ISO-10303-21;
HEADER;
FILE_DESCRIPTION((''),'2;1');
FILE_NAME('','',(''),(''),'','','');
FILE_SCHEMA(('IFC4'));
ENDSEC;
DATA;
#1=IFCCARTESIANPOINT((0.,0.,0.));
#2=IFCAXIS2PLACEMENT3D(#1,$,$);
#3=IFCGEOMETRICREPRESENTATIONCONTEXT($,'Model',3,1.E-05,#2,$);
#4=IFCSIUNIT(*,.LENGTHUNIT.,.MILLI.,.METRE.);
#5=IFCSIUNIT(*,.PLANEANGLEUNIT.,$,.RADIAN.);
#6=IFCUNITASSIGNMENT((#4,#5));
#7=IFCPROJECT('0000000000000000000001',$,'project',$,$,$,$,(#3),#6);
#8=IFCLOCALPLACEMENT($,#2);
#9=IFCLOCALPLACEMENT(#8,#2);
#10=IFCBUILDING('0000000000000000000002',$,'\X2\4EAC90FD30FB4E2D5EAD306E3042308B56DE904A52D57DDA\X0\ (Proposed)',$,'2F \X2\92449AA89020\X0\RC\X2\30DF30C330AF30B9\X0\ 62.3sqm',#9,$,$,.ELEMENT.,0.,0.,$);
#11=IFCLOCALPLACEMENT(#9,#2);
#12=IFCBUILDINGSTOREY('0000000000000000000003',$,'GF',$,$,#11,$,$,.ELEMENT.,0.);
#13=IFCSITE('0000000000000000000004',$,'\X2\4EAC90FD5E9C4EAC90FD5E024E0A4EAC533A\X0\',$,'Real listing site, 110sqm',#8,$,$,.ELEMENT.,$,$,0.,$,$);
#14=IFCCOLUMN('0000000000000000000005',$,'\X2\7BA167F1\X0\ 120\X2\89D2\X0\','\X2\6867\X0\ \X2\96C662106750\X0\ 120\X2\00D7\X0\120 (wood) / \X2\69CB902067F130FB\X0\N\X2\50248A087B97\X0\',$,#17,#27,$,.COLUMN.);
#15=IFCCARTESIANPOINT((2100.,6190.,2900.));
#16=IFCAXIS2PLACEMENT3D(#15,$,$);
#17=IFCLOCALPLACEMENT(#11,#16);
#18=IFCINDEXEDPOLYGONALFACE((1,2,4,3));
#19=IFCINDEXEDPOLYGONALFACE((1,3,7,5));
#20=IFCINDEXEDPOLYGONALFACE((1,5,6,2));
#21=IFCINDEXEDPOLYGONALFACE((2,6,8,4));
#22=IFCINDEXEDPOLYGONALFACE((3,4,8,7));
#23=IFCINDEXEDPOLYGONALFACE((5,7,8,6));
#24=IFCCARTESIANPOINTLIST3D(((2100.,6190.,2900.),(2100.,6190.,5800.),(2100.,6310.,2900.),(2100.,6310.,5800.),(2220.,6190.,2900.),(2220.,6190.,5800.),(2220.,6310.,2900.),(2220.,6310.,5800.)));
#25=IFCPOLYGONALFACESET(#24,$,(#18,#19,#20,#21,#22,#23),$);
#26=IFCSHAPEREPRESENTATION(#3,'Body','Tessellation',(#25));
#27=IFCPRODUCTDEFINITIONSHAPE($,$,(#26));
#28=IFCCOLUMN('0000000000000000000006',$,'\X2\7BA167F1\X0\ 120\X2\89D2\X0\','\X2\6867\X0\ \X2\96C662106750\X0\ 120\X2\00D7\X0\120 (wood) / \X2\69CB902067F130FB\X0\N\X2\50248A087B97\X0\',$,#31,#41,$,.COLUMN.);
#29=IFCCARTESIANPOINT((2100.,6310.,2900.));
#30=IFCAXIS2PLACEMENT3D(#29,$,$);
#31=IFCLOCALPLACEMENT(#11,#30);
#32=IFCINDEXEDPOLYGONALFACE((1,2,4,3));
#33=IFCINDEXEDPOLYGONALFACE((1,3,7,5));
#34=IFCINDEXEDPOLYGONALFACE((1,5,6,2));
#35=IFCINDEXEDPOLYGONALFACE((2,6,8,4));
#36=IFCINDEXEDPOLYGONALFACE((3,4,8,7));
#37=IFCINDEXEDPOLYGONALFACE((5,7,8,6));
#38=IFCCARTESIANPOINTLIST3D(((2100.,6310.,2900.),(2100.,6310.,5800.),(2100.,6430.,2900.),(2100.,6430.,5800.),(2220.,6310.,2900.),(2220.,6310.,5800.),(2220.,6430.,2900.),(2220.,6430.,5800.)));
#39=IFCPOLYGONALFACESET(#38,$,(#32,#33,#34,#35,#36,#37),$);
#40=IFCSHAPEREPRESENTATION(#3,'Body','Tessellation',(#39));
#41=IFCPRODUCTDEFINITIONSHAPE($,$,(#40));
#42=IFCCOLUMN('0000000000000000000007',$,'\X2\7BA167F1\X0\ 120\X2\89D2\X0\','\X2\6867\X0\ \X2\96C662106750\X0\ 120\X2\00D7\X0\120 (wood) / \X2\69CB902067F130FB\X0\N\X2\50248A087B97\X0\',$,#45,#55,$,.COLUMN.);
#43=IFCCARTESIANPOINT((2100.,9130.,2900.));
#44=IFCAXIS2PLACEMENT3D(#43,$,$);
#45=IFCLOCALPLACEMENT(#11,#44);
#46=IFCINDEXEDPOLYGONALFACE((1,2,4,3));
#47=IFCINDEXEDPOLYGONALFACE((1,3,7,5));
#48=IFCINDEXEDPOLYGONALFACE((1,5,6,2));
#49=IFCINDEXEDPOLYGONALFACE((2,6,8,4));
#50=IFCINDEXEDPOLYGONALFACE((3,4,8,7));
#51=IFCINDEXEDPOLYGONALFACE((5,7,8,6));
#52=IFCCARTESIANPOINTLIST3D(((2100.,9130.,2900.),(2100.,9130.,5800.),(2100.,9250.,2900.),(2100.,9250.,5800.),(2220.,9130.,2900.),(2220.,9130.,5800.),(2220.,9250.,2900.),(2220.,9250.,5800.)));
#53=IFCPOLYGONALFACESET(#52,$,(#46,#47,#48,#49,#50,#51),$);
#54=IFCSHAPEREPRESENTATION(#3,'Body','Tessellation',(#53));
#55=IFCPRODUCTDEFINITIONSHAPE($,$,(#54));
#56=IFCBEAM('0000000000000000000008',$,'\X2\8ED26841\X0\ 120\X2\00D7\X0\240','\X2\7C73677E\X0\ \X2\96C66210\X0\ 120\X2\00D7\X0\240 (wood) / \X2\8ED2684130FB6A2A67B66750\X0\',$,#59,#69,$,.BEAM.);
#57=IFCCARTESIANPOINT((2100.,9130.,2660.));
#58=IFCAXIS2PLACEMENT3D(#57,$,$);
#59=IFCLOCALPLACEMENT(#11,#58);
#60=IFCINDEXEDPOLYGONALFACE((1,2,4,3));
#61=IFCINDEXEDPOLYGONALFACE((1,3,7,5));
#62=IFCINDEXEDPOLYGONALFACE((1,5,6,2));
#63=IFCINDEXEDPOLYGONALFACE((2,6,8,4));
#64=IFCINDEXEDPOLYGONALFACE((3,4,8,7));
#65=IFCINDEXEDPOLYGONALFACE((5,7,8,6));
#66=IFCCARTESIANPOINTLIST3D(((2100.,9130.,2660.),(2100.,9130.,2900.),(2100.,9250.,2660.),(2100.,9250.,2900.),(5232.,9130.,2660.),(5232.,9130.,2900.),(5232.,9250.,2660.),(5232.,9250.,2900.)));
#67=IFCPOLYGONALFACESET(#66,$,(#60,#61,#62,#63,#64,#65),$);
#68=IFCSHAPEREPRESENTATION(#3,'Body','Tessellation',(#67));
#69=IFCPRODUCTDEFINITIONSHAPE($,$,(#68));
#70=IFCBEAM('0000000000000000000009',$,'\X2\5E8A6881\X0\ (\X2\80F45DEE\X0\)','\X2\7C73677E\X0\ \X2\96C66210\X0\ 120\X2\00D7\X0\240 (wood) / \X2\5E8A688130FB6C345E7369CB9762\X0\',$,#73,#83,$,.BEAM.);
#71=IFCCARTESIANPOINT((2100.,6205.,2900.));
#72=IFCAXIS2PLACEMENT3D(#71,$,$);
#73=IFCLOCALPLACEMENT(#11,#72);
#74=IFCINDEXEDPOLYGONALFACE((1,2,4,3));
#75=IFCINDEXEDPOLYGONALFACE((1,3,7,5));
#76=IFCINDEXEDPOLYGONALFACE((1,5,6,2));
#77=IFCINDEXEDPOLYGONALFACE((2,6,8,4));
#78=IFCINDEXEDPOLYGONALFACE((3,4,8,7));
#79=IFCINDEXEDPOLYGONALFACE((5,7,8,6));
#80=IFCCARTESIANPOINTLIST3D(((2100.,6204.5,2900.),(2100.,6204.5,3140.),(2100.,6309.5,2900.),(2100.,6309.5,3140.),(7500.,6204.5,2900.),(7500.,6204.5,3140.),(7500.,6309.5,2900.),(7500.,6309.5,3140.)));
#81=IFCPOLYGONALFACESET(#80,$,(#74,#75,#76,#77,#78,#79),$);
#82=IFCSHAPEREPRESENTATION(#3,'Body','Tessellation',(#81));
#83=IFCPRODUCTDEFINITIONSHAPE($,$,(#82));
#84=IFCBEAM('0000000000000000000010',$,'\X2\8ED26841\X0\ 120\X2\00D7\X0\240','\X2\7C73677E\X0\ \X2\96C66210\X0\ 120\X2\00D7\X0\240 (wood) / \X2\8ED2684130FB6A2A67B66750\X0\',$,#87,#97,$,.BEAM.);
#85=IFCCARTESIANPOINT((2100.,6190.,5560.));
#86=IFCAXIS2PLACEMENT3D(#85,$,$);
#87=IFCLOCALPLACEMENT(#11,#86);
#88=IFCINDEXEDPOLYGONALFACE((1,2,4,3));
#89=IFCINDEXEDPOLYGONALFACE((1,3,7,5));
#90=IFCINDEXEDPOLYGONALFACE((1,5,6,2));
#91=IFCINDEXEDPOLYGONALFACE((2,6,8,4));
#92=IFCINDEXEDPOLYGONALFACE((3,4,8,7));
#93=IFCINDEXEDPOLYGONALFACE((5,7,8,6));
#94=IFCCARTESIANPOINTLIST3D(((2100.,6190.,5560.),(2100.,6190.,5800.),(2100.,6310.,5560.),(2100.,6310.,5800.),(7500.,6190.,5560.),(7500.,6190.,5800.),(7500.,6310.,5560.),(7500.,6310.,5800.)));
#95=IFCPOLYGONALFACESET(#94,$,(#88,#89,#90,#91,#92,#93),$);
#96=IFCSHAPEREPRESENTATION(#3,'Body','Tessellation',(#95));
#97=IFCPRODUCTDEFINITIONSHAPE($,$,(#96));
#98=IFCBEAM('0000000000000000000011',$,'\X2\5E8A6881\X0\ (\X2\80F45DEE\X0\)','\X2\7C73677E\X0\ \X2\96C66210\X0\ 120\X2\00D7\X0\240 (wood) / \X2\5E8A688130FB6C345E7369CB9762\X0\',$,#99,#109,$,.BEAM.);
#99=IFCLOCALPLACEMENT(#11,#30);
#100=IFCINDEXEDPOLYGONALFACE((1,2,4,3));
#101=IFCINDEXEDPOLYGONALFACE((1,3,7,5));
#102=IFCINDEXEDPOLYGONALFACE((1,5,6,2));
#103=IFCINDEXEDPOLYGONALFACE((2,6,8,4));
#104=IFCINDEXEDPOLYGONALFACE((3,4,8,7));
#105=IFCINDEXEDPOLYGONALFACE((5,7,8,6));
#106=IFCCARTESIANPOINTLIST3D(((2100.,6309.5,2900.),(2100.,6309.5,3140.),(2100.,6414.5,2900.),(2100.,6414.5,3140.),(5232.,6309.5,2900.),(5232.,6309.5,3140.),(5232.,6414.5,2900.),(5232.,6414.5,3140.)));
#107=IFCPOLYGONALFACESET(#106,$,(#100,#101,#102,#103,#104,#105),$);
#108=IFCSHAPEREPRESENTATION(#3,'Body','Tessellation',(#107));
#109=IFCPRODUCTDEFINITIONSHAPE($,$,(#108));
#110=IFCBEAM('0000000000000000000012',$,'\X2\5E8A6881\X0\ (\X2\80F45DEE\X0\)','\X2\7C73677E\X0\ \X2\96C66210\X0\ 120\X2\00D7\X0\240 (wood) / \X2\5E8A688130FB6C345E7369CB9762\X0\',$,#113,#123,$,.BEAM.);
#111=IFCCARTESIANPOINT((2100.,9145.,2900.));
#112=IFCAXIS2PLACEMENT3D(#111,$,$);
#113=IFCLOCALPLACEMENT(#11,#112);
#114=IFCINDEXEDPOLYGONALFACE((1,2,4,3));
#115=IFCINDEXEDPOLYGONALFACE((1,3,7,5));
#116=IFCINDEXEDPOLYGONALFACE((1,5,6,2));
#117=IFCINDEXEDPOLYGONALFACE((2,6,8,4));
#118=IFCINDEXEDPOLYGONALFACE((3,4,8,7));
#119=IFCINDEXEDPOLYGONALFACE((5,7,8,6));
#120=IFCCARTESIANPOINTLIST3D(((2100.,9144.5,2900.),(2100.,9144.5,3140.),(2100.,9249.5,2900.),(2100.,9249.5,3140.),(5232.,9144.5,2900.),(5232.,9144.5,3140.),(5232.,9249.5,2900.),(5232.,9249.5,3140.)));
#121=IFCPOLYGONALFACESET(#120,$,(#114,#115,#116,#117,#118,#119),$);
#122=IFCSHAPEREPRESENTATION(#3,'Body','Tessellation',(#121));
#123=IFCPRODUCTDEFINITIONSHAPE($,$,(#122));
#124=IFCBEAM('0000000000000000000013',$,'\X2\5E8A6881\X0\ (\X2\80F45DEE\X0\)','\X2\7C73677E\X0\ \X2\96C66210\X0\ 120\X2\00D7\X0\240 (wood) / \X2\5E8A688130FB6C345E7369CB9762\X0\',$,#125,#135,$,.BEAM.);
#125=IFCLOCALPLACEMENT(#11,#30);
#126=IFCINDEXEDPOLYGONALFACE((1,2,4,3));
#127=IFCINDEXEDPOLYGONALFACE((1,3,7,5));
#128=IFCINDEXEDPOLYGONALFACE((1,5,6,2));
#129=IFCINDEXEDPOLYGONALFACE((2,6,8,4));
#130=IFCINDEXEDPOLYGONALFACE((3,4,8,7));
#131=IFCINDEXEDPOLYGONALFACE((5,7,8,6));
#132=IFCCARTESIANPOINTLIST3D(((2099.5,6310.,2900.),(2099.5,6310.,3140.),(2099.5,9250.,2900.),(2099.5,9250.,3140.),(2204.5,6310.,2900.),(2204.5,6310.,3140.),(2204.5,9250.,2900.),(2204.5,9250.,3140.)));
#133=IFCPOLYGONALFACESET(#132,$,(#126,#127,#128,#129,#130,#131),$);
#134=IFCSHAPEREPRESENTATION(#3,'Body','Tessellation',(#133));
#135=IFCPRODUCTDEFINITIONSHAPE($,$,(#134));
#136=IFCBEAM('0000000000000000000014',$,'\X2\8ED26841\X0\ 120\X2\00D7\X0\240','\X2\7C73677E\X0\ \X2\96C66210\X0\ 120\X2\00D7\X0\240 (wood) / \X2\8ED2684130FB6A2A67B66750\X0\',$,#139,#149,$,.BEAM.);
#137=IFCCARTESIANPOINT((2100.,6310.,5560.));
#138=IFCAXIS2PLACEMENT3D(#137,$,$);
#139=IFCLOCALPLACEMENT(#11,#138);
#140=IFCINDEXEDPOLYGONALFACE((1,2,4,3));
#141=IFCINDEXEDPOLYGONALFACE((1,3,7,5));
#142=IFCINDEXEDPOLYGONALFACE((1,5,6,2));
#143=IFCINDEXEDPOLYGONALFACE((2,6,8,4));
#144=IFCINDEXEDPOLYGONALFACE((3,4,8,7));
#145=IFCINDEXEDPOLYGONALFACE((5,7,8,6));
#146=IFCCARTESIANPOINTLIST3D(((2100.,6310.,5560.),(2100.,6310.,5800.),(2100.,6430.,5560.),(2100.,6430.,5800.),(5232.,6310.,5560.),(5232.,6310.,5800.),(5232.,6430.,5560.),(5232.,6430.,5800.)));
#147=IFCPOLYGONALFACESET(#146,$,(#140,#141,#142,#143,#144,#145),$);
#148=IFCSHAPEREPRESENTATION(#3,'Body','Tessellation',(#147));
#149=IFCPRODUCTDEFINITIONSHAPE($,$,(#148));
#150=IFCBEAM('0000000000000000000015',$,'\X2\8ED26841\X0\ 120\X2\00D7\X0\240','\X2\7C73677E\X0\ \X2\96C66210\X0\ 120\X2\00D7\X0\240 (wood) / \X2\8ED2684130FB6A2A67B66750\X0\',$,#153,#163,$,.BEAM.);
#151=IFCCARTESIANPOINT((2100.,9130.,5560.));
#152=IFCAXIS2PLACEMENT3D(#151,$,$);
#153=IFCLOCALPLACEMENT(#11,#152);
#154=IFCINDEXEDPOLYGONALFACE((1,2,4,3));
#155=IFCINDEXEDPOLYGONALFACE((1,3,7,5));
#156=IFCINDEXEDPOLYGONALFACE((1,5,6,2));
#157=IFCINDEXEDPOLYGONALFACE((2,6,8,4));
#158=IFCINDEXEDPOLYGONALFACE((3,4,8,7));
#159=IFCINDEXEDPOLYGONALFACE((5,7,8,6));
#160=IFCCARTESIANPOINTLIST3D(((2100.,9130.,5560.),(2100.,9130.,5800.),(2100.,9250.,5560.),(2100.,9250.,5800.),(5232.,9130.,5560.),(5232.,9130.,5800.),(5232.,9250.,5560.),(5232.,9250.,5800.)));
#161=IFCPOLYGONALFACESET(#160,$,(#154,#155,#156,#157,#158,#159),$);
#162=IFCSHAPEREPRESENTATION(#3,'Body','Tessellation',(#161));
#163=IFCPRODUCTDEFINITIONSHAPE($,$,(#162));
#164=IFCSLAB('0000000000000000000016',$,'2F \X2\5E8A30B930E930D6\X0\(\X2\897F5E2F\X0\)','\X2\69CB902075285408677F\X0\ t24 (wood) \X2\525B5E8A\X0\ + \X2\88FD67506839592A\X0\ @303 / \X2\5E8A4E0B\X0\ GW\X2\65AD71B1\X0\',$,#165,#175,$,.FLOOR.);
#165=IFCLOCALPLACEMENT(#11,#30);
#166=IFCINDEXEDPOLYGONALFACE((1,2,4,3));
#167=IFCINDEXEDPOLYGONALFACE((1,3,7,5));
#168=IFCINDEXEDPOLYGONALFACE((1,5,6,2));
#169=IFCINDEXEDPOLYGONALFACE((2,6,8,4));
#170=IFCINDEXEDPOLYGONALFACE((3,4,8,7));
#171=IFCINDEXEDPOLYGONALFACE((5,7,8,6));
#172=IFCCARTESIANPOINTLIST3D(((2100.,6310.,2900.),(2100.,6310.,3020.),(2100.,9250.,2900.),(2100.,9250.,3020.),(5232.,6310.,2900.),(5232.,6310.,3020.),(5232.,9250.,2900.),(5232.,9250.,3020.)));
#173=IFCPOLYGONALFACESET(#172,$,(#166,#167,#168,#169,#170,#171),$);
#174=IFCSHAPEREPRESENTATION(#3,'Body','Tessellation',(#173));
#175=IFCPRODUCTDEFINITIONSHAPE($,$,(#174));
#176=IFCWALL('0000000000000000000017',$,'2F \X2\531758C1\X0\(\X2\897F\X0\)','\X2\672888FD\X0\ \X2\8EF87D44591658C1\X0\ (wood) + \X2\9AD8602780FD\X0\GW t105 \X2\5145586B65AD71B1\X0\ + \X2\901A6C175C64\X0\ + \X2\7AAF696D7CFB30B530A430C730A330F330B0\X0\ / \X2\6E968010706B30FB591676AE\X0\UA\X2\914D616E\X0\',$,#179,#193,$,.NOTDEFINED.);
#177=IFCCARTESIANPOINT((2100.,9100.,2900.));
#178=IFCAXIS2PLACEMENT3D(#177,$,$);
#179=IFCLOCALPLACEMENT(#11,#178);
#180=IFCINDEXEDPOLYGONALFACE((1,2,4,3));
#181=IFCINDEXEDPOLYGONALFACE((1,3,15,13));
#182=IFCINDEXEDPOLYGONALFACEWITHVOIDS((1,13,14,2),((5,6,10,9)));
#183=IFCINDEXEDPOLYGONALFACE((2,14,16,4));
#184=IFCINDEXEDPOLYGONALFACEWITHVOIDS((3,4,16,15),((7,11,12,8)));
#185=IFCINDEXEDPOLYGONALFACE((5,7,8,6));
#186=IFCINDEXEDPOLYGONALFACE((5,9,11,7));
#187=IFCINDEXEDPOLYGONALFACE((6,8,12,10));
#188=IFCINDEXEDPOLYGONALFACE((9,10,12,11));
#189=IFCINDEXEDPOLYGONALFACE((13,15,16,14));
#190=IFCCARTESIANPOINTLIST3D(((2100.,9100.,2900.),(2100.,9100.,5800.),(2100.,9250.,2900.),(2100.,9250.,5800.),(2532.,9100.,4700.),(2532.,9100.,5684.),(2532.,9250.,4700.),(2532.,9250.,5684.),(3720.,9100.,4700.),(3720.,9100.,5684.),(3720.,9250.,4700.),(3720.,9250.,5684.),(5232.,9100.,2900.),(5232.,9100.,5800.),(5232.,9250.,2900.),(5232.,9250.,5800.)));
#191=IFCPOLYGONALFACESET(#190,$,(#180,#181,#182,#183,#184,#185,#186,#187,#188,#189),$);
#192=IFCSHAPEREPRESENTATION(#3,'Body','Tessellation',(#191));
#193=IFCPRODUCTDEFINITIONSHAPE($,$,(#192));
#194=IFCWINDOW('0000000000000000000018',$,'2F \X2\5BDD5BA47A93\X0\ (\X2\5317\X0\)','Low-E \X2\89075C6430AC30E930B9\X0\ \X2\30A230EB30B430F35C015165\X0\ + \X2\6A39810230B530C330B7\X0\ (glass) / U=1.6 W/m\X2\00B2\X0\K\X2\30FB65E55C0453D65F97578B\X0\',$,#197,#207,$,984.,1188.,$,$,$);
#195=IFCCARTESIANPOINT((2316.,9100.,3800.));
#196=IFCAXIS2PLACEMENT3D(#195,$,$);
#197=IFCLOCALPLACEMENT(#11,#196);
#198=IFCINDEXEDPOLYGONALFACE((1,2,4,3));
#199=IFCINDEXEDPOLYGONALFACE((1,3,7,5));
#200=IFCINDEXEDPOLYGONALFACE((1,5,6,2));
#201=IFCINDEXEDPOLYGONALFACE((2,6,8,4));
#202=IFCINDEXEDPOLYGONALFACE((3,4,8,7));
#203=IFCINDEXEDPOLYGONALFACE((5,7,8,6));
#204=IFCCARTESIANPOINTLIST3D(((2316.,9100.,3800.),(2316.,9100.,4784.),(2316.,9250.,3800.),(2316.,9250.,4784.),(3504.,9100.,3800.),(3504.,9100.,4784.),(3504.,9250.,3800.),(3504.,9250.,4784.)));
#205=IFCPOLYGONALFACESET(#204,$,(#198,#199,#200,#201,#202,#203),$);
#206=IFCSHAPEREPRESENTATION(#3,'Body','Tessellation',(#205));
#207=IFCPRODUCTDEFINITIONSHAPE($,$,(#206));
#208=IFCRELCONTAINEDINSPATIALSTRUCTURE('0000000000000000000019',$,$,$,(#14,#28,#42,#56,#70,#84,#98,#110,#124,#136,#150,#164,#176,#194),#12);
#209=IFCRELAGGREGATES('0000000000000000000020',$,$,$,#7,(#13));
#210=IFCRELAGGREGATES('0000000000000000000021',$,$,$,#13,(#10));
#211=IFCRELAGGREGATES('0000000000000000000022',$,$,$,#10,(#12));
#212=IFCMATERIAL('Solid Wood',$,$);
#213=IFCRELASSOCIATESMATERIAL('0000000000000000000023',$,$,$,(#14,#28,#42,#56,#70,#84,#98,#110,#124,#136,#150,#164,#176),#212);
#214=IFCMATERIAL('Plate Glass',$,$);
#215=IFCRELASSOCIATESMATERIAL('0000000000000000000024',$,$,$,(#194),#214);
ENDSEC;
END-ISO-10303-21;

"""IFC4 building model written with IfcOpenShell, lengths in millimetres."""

from ifc_helpers import new_model, si_unit, frame, frame_2d, origin, place, context, project, spatial, rectangle, extrude, material, element, fill, save


model = new_model("IFC4")

# Units and contexts
model_context = context("Model", 3, precision=1e-05, world=origin())
ifc_project = project(units=[si_unit("LENGTHUNIT", "METRE", prefix="MILLI"), si_unit("PLANEANGLEUNIT", "RADIAN")], contexts=[model_context])

# Site, building, storey
site_placement = place(None, origin())
site = spatial("IfcSite", under=ifc_project, at=site_placement, Name="京都府京都市上京区", ObjectType="Real listing site, 110sqm", CompositionType="ELEMENT", RefElevation=0.0)
building_placement = place(site_placement, origin())
building = spatial("IfcBuilding", under=site, at=building_placement, Name="京都・中庭のある回遊動線 (Proposed)", ObjectType="2F 鉄骨造RCミックス 62.3sqm", CompositionType="ELEMENT", ElevationOfRefHeight=0.0, ElevationOfTerrain=0.0)
storey_placement = place(building_placement, origin())
storey = spatial("IfcBuildingStorey", under=building, at=storey_placement, Name="GF", CompositionType="ELEMENT", Elevation=0.0)

# Columns
ifc_material_1 = material(Name="Solid Wood")
column_1_placement = place(storey_placement, frame((2100.0, 6190.0, 2900.0)))
element("IfcColumn", 1, at=column_1_placement, inside=storey, material=ifc_material_1, Name="管柱 120角", Description="桧 集成材 120×120 (wood) / 構造柱・N値計算", PredefinedType="COLUMN", context=model_context, shape_type="SweptSolid", body=[
    extrude(rectangle(XDim=120.0, YDim=120.0, at=frame_2d((60.0, 60.0))), frame((2100.0, 6190.0, 2900.0)), (0.0, 0.0, 1.0), 2900.0),
])
column_2_placement = place(storey_placement, frame((2100.0, 6310.0, 2900.0)))
element("IfcColumn", 2, at=column_2_placement, inside=storey, material=ifc_material_1, Name="管柱 120角", Description="桧 集成材 120×120 (wood) / 構造柱・N値計算", PredefinedType="COLUMN", context=model_context, shape_type="SweptSolid", body=[
    extrude(rectangle(XDim=120.0, YDim=120.0, at=frame_2d((60.0, 60.0))), frame((2100.0, 6310.0, 2900.0)), (0.0, 0.0, 1.0), 2900.0),
])
column_3_placement = place(storey_placement, frame((2100.0, 9130.0, 2900.0)))
element("IfcColumn", 3, at=column_3_placement, inside=storey, material=ifc_material_1, Name="管柱 120角", Description="桧 集成材 120×120 (wood) / 構造柱・N値計算", PredefinedType="COLUMN", context=model_context, shape_type="SweptSolid", body=[
    extrude(rectangle(XDim=120.0, YDim=120.0, at=frame_2d((60.0, 60.0))), frame((2100.0, 9130.0, 2900.0)), (0.0, 0.0, 1.0), 2900.0),
])

# Beams
beam_1_placement = place(storey_placement, frame((2100.0, 9130.0, 2660.0)))
element("IfcBeam", 4, at=beam_1_placement, inside=storey, material=ifc_material_1, Name="軒桁 120×240", Description="米松 集成 120×240 (wood) / 軒桁・横架材", PredefinedType="BEAM", context=model_context, shape_type="SweptSolid", body=[
    extrude(rectangle(XDim=3132.0, YDim=120.0, at=frame_2d((1566.0, 60.0))), frame((2100.0, 9130.0, 2660.0)), (0.0, 0.0, 1.0), 240.0),
])
beam_2_placement = place(storey_placement, frame((2100.0, 6205.0, 2900.0)))
element("IfcBeam", 5, at=beam_2_placement, inside=storey, material=ifc_material_1, Name="床梁 (胴差)", Description="米松 集成 120×240 (wood) / 床梁・水平構面", PredefinedType="BEAM", context=model_context, shape_type="SweptSolid", body=[
    extrude(rectangle(XDim=5400.0, YDim=105.0, at=frame_2d((2700.0, 52.0))), frame((2100.0, 6205.0, 2900.0)), (0.0, 0.0, 1.0), 240.0),
])
beam_3_placement = place(storey_placement, frame((2100.0, 6190.0, 5560.0)))
element("IfcBeam", 6, at=beam_3_placement, inside=storey, material=ifc_material_1, Name="軒桁 120×240", Description="米松 集成 120×240 (wood) / 軒桁・横架材", PredefinedType="BEAM", context=model_context, shape_type="SweptSolid", body=[
    extrude(rectangle(XDim=5400.0, YDim=120.0, at=frame_2d((2700.0, 60.0))), frame((2100.0, 6190.0, 5560.0)), (0.0, 0.0, 1.0), 240.0),
])
beam_4_placement = place(storey_placement, frame((2100.0, 6310.0, 2900.0)))
element("IfcBeam", 7, at=beam_4_placement, inside=storey, material=ifc_material_1, Name="床梁 (胴差)", Description="米松 集成 120×240 (wood) / 床梁・水平構面", PredefinedType="BEAM", context=model_context, shape_type="SweptSolid", body=[
    extrude(rectangle(XDim=3132.0, YDim=105.0, at=frame_2d((1566.0, 52.0))), frame((2100.0, 6310.0, 2900.0)), (0.0, 0.0, 1.0), 240.0),
])
beam_5_placement = place(storey_placement, frame((2100.0, 9145.0, 2900.0)))
element("IfcBeam", 8, at=beam_5_placement, inside=storey, material=ifc_material_1, Name="床梁 (胴差)", Description="米松 集成 120×240 (wood) / 床梁・水平構面", PredefinedType="BEAM", context=model_context, shape_type="SweptSolid", body=[
    extrude(rectangle(XDim=3132.0, YDim=105.0, at=frame_2d((1566.0, 52.0))), frame((2100.0, 9145.0, 2900.0)), (0.0, 0.0, 1.0), 240.0),
])
beam_6_placement = place(storey_placement, frame((2100.0, 6310.0, 2900.0)))
element("IfcBeam", 9, at=beam_6_placement, inside=storey, material=ifc_material_1, Name="床梁 (胴差)", Description="米松 集成 120×240 (wood) / 床梁・水平構面", PredefinedType="BEAM", context=model_context, shape_type="SweptSolid", body=[
    extrude(rectangle(XDim=105.0, YDim=2940.0, at=frame_2d((52.0, 1470.0))), frame((2100.0, 6310.0, 2900.0)), (0.0, 0.0, 1.0), 240.0),
])
beam_7_placement = place(storey_placement, frame((2100.0, 6310.0, 5560.0)))
element("IfcBeam", 10, at=beam_7_placement, inside=storey, material=ifc_material_1, Name="軒桁 120×240", Description="米松 集成 120×240 (wood) / 軒桁・横架材", PredefinedType="BEAM", context=model_context, shape_type="SweptSolid", body=[
    extrude(rectangle(XDim=3132.0, YDim=120.0, at=frame_2d((1566.0, 60.0))), frame((2100.0, 6310.0, 5560.0)), (0.0, 0.0, 1.0), 240.0),
])
beam_8_placement = place(storey_placement, frame((2100.0, 9130.0, 5560.0)))
element("IfcBeam", 11, at=beam_8_placement, inside=storey, material=ifc_material_1, Name="軒桁 120×240", Description="米松 集成 120×240 (wood) / 軒桁・横架材", PredefinedType="BEAM", context=model_context, shape_type="SweptSolid", body=[
    extrude(rectangle(XDim=3132.0, YDim=120.0, at=frame_2d((1566.0, 60.0))), frame((2100.0, 9130.0, 5560.0)), (0.0, 0.0, 1.0), 240.0),
])

# Slab
slab_placement = place(storey_placement, frame((2100.0, 6310.0, 2900.0)))
element("IfcSlab", 12, at=slab_placement, inside=storey, material=ifc_material_1, Name="2F 床スラブ(西帯)", Description="構造用合板 t24 (wood) 剛床 + 製材根太 @303 / 床下 GW断熱", PredefinedType="FLOOR", context=model_context, shape_type="SweptSolid", body=[
    extrude(rectangle(XDim=3132.0, YDim=2940.0, at=frame_2d((1566.0, 1470.0))), frame((2100.0, 6310.0, 2900.0)), (0.0, 0.0, 1.0), 120.0),
])

# Wall, opening, window
wall_1_placement = place(storey_placement, frame((2100.0, 9100.0, 2900.0)))
wall_1 = element("IfcWall", 13, at=wall_1_placement, inside=storey, material=ifc_material_1, Name="2F 北壁(西)", Description="木製 軸組外壁 (wood) + 高性能GW t105 充填断熱 + 通気層 + 窯業系サイディング / 準耐火・外皮UA配慮", PredefinedType="NOTDEFINED", context=model_context, shape_type="SweptSolid", body=[
    extrude(rectangle(XDim=3132.0, YDim=150.0, at=frame_2d((1566.0, 75.0))), frame((2100.0, 9100.0, 2900.0)), (0.0, 0.0, 1.0), 2900.0),
])
opening_placement = place(storey_placement, frame((2316.0, 9100.0, 3800.0)))
opening = element("IfcOpeningElement", 14, at=opening_placement, cuts=wall_1, PredefinedType="NOTDEFINED", context=model_context, shape_type="SweptSolid", body=[
    extrude(rectangle(XDim=1188.0, YDim=150.0, at=frame_2d((594.0, 75.0))), frame((2316.0, 9100.0, 3800.0)), (0.0, 0.0, 1.0), 984.0),
])
ifc_material_2 = material(Name="Plate Glass")
window_placement = place(storey_placement, frame((2316.0, 9100.0, 3800.0)))
window = element("IfcWindow", 15, at=window_placement, inside=storey, material=ifc_material_2, Name="2F 寝室窓 (北)", Description="Low-E 複層ガラス アルゴン封入 + 樹脂サッシ (glass) / U=1.6 W/m²K・日射取得型", OverallHeight=984.0, OverallWidth=1188.0, context=model_context, shape_type="SweptSolid", body=[
    extrude(rectangle(XDim=1188.0, YDim=150.0, at=frame_2d((594.0, 75.0))), frame((2316.0, 9100.0, 3800.0)), (0.0, 0.0, 1.0), 984.0),
])
fill(opening, window)

save(model, "model.ifc")
